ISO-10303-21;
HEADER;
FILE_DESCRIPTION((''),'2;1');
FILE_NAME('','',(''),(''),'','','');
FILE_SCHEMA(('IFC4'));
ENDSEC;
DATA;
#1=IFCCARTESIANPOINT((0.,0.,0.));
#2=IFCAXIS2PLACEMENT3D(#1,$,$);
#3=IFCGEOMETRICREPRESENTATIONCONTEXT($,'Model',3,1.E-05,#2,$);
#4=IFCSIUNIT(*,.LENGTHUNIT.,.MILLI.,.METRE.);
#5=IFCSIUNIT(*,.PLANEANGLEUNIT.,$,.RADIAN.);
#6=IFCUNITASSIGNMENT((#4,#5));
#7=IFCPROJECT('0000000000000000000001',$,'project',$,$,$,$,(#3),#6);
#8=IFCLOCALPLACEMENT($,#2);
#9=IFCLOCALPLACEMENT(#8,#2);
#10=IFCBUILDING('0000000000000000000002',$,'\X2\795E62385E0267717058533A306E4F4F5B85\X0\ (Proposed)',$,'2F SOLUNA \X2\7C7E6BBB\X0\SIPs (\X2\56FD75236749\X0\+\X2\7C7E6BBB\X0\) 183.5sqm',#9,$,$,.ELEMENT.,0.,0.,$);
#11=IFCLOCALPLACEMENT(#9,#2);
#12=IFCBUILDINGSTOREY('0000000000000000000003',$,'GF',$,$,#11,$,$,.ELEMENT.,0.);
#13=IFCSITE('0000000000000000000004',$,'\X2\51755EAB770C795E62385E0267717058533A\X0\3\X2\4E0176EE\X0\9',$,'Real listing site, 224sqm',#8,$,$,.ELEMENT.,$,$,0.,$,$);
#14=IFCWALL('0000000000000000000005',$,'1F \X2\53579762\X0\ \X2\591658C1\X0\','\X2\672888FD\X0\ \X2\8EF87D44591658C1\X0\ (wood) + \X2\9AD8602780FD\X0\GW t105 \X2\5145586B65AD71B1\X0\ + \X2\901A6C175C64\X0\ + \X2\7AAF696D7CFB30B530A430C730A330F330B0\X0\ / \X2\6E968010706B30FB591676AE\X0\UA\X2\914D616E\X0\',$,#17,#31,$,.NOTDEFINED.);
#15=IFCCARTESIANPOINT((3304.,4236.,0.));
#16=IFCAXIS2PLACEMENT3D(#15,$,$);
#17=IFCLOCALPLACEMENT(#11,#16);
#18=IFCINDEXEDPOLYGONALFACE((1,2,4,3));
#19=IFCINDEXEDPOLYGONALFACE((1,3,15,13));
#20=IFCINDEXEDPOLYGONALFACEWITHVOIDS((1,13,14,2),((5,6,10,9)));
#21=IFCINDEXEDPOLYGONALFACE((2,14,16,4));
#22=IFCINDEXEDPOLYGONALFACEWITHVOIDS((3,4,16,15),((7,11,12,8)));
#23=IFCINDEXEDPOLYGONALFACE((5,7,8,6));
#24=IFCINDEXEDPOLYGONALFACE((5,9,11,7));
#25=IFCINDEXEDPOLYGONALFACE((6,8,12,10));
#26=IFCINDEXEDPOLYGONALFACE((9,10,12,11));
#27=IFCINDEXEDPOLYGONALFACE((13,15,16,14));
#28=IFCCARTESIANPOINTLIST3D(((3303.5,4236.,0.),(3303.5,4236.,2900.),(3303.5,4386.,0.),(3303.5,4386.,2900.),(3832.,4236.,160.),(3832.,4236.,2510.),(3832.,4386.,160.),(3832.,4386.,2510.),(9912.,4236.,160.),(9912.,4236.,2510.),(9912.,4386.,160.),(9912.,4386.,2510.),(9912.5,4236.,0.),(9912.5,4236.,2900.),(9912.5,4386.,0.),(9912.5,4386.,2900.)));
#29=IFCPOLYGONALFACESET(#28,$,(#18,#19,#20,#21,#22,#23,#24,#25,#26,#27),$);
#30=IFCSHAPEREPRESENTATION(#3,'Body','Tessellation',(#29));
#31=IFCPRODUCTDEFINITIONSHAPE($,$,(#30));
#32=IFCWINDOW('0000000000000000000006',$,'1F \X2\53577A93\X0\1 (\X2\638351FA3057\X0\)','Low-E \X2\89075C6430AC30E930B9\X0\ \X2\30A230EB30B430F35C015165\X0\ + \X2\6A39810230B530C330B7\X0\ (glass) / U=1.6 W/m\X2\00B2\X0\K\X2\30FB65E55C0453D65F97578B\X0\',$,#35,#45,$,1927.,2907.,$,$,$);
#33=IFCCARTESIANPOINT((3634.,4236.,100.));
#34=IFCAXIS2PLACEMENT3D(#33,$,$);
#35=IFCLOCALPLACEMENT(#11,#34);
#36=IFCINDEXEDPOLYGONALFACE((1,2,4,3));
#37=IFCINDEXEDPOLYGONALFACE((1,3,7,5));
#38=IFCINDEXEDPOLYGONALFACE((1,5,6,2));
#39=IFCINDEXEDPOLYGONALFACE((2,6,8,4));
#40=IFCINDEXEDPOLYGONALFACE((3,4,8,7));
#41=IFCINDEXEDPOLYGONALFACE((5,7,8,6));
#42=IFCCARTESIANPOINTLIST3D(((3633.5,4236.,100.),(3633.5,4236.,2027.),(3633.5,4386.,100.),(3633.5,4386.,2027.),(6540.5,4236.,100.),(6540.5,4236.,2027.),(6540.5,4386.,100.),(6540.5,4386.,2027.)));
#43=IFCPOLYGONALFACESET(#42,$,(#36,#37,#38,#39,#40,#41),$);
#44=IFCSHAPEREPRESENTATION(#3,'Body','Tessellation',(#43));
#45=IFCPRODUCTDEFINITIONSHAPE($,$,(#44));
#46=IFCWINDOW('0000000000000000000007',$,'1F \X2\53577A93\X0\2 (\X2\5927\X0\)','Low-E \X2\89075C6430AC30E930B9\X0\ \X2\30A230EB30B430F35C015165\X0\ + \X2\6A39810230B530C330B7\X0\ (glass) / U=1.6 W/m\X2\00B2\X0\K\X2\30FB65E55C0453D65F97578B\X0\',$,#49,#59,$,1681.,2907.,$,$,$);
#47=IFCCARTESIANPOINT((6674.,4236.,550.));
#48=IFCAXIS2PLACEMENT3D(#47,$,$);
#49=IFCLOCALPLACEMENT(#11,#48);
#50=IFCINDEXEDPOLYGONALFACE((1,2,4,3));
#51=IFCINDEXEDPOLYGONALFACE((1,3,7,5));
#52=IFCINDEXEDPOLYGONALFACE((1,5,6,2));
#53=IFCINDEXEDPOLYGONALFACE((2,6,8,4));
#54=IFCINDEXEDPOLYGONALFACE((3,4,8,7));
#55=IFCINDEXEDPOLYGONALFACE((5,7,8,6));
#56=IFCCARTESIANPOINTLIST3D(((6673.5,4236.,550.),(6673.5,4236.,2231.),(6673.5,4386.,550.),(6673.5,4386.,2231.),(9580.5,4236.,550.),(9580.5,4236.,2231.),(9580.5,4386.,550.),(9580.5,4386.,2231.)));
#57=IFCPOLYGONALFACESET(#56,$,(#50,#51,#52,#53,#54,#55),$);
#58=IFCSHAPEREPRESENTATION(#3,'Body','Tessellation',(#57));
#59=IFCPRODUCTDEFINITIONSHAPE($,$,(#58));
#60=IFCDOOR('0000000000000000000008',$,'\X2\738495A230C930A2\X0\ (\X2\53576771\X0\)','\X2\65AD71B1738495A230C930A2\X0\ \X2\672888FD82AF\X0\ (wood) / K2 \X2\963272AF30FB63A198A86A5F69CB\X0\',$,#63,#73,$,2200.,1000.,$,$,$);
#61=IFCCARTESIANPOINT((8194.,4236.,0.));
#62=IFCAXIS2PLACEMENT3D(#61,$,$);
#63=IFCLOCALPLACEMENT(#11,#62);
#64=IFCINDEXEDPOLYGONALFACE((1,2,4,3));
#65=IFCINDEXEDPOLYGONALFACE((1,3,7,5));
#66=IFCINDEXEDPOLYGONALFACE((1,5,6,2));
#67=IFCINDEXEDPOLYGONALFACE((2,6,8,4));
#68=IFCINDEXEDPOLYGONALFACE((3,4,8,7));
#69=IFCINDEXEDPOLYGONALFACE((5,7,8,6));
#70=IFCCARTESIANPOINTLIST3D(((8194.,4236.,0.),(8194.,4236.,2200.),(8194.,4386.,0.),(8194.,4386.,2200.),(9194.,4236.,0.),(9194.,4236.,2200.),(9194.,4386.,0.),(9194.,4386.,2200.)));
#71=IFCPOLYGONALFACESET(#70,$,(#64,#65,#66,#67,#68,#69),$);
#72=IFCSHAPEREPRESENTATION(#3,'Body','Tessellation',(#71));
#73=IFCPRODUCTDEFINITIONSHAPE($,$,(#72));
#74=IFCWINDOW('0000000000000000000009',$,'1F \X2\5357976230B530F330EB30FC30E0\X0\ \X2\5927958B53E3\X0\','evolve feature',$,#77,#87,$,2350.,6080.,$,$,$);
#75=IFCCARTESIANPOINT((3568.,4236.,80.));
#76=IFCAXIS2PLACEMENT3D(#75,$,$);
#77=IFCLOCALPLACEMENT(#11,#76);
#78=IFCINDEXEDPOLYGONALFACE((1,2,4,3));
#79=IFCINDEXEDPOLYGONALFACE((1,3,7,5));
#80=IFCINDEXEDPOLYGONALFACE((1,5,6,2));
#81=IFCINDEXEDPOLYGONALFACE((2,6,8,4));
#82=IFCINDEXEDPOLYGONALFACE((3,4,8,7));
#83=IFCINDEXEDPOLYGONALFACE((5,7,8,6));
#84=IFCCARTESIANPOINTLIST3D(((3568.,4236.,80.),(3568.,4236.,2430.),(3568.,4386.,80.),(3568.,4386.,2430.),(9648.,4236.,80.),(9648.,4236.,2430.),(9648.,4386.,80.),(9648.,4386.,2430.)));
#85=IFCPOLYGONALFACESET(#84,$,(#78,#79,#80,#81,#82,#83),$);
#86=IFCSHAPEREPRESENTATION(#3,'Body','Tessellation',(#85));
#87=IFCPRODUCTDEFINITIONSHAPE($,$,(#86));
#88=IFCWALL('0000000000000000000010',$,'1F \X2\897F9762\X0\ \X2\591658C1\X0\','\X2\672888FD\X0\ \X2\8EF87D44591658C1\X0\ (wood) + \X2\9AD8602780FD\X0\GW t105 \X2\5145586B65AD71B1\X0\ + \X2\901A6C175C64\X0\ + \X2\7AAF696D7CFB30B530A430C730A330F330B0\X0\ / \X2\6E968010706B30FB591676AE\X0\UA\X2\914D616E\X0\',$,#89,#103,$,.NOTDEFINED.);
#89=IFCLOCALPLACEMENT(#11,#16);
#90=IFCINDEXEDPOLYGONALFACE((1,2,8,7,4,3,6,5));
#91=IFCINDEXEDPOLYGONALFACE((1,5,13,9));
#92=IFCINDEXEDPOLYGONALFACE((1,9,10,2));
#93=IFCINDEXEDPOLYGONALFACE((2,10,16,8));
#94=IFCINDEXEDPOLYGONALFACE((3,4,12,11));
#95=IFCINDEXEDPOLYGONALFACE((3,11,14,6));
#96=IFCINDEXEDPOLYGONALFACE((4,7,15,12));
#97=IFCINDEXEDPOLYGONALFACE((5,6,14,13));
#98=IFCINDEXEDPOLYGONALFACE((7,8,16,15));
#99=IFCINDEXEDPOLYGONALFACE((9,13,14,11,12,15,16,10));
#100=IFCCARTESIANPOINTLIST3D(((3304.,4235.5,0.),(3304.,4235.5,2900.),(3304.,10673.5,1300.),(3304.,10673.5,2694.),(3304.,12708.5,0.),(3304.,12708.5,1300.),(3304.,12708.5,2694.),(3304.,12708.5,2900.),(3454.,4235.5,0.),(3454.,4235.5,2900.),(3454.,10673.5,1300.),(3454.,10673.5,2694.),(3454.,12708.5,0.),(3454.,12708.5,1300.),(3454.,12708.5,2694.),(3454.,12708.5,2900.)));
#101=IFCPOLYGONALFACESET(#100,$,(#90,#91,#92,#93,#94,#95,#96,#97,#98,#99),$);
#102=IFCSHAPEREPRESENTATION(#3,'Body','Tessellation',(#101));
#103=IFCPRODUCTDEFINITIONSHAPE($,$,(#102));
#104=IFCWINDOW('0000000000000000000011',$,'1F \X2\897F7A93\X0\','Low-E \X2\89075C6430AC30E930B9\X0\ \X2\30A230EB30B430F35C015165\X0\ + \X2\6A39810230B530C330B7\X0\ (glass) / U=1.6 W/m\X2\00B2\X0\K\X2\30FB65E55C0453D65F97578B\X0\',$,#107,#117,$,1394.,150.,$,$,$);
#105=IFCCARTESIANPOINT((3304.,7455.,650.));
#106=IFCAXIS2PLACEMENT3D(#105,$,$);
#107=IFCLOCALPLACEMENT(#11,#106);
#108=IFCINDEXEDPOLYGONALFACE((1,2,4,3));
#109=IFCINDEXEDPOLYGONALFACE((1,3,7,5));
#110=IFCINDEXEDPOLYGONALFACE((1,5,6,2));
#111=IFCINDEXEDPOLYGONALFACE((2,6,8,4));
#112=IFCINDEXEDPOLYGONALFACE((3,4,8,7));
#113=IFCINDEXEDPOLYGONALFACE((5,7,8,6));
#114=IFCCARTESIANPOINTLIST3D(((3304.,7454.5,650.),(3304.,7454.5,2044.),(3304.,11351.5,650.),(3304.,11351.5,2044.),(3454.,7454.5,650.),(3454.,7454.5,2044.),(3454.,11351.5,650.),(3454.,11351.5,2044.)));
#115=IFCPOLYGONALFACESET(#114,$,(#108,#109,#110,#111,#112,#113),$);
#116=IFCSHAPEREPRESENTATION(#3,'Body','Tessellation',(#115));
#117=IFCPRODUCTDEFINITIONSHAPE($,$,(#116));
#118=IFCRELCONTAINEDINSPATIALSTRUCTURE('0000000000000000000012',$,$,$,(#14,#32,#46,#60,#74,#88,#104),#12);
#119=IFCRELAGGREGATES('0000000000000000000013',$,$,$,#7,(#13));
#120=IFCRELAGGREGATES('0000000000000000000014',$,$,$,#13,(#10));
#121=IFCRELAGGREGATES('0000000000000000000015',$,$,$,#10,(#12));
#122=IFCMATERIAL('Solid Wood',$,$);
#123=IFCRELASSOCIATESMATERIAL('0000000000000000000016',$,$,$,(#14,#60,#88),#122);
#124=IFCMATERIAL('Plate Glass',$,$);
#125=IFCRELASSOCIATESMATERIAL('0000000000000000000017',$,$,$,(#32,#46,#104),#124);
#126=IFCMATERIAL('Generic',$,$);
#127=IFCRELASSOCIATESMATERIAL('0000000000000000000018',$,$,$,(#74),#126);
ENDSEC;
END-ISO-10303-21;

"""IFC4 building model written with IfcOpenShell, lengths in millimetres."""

from ifc_helpers import new_model, si_unit, frame, frame_2d, origin, place, context, project, spatial, rectangle, extrude, material, element, fill, save


model = new_model("IFC4")

# Units and contexts
model_context = context("Model", 3, precision=1e-05, world=origin())
ifc_project = project(units=[si_unit("LENGTHUNIT", "METRE", prefix="MILLI"), si_unit("PLANEANGLEUNIT", "RADIAN")], contexts=[model_context])

# Site, building, storey
site_placement = place(None, origin())
site = spatial("IfcSite", under=ifc_project, at=site_placement, Name="兵庫県神戸市東灘区3丁目9", ObjectType="Real listing site, 224sqm", CompositionType="ELEMENT", RefElevation=0.0)
building_placement = place(site_placement, origin())
building = spatial("IfcBuilding", under=site, at=building_placement, Name="神戸市東灘区の住宅 (Proposed)", ObjectType="2F SOLUNA 籾殻SIPs (国産杉+籾殻) 183.5sqm", CompositionType="ELEMENT", ElevationOfRefHeight=0.0, ElevationOfTerrain=0.0)
storey_placement = place(building_placement, origin())
storey = spatial("IfcBuildingStorey", under=building, at=storey_placement, Name="GF", CompositionType="ELEMENT", Elevation=0.0)

# Shared definitions
ifc_material_1 = material(Name="Solid Wood")
ifc_material_2 = material(Name="Generic")

# Wall, openings, windows, door
wall_1_placement = place(storey_placement, frame((3304.0, 4236.0, 0.0)))
wall_1 = element("IfcWall", 1, at=wall_1_placement, inside=storey, material=ifc_material_1, Name="1F 南面 外壁", Description="木製 軸組外壁 (wood) + 高性能GW t105 充填断熱 + 通気層 + 窯業系サイディング / 準耐火・外皮UA配慮", PredefinedType="NOTDEFINED", context=model_context, shape_type="SweptSolid", body=[
    extrude(rectangle(XDim=6609.0, YDim=150.0, at=frame_2d((3304.0, 75.0))), frame((3304.0, 4236.0, 0.0)), (0.0, 0.0, 1.0), 2900.0),
])
opening_1_placement = place(storey_placement, frame((3634.0, 4236.0, 100.0)))
opening_1 = element("IfcOpeningElement", 2, at=opening_1_placement, cuts=wall_1, PredefinedType="NOTDEFINED", context=model_context, shape_type="SweptSolid", body=[
    extrude(rectangle(XDim=2907.0, YDim=150.0, at=frame_2d((1453.0, 75.0))), frame((3634.0, 4236.0, 100.0)), (0.0, 0.0, 1.0), 1927.0),
])
opening_2_placement = place(storey_placement, frame((6674.0, 4236.0, 550.0)))
opening_2 = element("IfcOpeningElement", 3, at=opening_2_placement, cuts=wall_1, PredefinedType="NOTDEFINED", context=model_context, shape_type="SweptSolid", body=[
    extrude(rectangle(XDim=2907.0, YDim=150.0, at=frame_2d((1453.0, 75.0))), frame((6674.0, 4236.0, 550.0)), (0.0, 0.0, 1.0), 1681.0),
])
opening_3_placement = place(storey_placement, frame((8194.0, 4236.0, 0.0)))
opening_3 = element("IfcOpeningElement", 4, at=opening_3_placement, cuts=wall_1, PredefinedType="NOTDEFINED", context=model_context, shape_type="SweptSolid", body=[
    extrude(rectangle(XDim=1000.0, YDim=150.0, at=frame_2d((500.0, 75.0))), frame((8194.0, 4236.0, 0.0)), (0.0, 0.0, 1.0), 2200.0),
])
opening_4_placement = place(storey_placement, frame((3568.0, 4236.0, 80.0)))
opening_4 = element("IfcOpeningElement", 5, at=opening_4_placement, cuts=wall_1, PredefinedType="NOTDEFINED", context=model_context, shape_type="SweptSolid", body=[
    extrude(rectangle(XDim=6080.0, YDim=150.0, at=frame_2d((3040.0, 75.0))), frame((3568.0, 4236.0, 80.0)), (0.0, 0.0, 1.0), 2350.0),
])
ifc_material_3 = material(Name="Plate Glass")
window_1_placement = place(storey_placement, frame((3634.0, 4236.0, 100.0)))
window_1 = element("IfcWindow", 6, at=window_1_placement, inside=storey, material=ifc_material_3, Name="1F 南窓1 (掃出し)", Description="Low-E 複層ガラス アルゴン封入 + 樹脂サッシ (glass) / U=1.6 W/m²K・日射取得型", OverallHeight=1927.0, OverallWidth=2907.0, context=model_context, shape_type="SweptSolid", body=[
    extrude(rectangle(XDim=2907.0, YDim=150.0, at=frame_2d((1453.0, 75.0))), frame((3634.0, 4236.0, 100.0)), (0.0, 0.0, 1.0), 1927.0),
])
fill(opening_1, window_1)
window_2_placement = place(storey_placement, frame((6674.0, 4236.0, 550.0)))
window_2 = element("IfcWindow", 7, at=window_2_placement, inside=storey, material=ifc_material_3, Name="1F 南窓2 (大)", Description="Low-E 複層ガラス アルゴン封入 + 樹脂サッシ (glass) / U=1.6 W/m²K・日射取得型", OverallHeight=1681.0, OverallWidth=2907.0, context=model_context, shape_type="SweptSolid", body=[
    extrude(rectangle(XDim=2907.0, YDim=150.0, at=frame_2d((1453.0, 75.0))), frame((6674.0, 4236.0, 550.0)), (0.0, 0.0, 1.0), 1681.0),
])
fill(opening_2, window_2)
door_placement = place(storey_placement, frame((8194.0, 4236.0, 0.0)))
door = element("IfcDoor", 8, at=door_placement, inside=storey, material=ifc_material_1, Name="玄関ドア (南東)", Description="断熱玄関ドア 木製芯 (wood) / K2 防犯・採風機構", OverallHeight=2200.0, OverallWidth=1000.0, context=model_context, shape_type="SweptSolid", body=[
    extrude(rectangle(XDim=1000.0, YDim=150.0, at=frame_2d((500.0, 75.0))), frame((8194.0, 4236.0, 0.0)), (0.0, 0.0, 1.0), 2200.0),
])
fill(opening_3, door)
window_3_placement = place(storey_placement, frame((3568.0, 4236.0, 80.0)))
window_3 = element("IfcWindow", 9, at=window_3_placement, inside=storey, material=ifc_material_2, Name="1F 南面サンルーム 大開口", Description="evolve feature", OverallHeight=2350.0, OverallWidth=6080.0, context=model_context, shape_type="SweptSolid", body=[
    extrude(rectangle(XDim=6080.0, YDim=150.0, at=frame_2d((3040.0, 75.0))), frame((3568.0, 4236.0, 80.0)), (0.0, 0.0, 1.0), 2350.0),
])
fill(opening_4, window_3)

# Wall, opening, window
wall_2_placement = place(storey_placement, frame((3304.0, 4236.0, 0.0)))
wall_2 = element("IfcWall", 10, at=wall_2_placement, inside=storey, material=ifc_material_1, Name="1F 西面 外壁", Description="木製 軸組外壁 (wood) + 高性能GW t105 充填断熱 + 通気層 + 窯業系サイディング / 準耐火・外皮UA配慮", PredefinedType="NOTDEFINED", context=model_context, shape_type="SweptSolid", body=[
    extrude(rectangle(XDim=150.0, YDim=8473.0, at=frame_2d((75.0, 4236.0))), frame((3304.0, 4236.0, 0.0)), (0.0, 0.0, 1.0), 2900.0),
])
opening_5_placement = place(storey_placement, frame((3304.0, 7455.0, 650.0)))
opening_5 = element("IfcOpeningElement", 11, at=opening_5_placement, cuts=wall_2, PredefinedType="NOTDEFINED", context=model_context, shape_type="SweptSolid", body=[
    extrude(rectangle(XDim=150.0, YDim=3897.0, at=frame_2d((75.0, 1948.0))), frame((3304.0, 7455.0, 650.0)), (0.0, 0.0, 1.0), 1394.0),
])
window_4_placement = place(storey_placement, frame((3304.0, 7455.0, 650.0)))
window_4 = element("IfcWindow", 12, at=window_4_placement, inside=storey, material=ifc_material_3, Name="1F 西窓", Description="Low-E 複層ガラス アルゴン封入 + 樹脂サッシ (glass) / U=1.6 W/m²K・日射取得型", OverallHeight=1394.0, OverallWidth=150.0, context=model_context, shape_type="SweptSolid", body=[
    extrude(rectangle(XDim=150.0, YDim=3897.0, at=frame_2d((75.0, 1948.0))), frame((3304.0, 7455.0, 650.0)), (0.0, 0.0, 1.0), 1394.0),
])
fill(opening_5, window_4)

save(model, "model.ifc")
